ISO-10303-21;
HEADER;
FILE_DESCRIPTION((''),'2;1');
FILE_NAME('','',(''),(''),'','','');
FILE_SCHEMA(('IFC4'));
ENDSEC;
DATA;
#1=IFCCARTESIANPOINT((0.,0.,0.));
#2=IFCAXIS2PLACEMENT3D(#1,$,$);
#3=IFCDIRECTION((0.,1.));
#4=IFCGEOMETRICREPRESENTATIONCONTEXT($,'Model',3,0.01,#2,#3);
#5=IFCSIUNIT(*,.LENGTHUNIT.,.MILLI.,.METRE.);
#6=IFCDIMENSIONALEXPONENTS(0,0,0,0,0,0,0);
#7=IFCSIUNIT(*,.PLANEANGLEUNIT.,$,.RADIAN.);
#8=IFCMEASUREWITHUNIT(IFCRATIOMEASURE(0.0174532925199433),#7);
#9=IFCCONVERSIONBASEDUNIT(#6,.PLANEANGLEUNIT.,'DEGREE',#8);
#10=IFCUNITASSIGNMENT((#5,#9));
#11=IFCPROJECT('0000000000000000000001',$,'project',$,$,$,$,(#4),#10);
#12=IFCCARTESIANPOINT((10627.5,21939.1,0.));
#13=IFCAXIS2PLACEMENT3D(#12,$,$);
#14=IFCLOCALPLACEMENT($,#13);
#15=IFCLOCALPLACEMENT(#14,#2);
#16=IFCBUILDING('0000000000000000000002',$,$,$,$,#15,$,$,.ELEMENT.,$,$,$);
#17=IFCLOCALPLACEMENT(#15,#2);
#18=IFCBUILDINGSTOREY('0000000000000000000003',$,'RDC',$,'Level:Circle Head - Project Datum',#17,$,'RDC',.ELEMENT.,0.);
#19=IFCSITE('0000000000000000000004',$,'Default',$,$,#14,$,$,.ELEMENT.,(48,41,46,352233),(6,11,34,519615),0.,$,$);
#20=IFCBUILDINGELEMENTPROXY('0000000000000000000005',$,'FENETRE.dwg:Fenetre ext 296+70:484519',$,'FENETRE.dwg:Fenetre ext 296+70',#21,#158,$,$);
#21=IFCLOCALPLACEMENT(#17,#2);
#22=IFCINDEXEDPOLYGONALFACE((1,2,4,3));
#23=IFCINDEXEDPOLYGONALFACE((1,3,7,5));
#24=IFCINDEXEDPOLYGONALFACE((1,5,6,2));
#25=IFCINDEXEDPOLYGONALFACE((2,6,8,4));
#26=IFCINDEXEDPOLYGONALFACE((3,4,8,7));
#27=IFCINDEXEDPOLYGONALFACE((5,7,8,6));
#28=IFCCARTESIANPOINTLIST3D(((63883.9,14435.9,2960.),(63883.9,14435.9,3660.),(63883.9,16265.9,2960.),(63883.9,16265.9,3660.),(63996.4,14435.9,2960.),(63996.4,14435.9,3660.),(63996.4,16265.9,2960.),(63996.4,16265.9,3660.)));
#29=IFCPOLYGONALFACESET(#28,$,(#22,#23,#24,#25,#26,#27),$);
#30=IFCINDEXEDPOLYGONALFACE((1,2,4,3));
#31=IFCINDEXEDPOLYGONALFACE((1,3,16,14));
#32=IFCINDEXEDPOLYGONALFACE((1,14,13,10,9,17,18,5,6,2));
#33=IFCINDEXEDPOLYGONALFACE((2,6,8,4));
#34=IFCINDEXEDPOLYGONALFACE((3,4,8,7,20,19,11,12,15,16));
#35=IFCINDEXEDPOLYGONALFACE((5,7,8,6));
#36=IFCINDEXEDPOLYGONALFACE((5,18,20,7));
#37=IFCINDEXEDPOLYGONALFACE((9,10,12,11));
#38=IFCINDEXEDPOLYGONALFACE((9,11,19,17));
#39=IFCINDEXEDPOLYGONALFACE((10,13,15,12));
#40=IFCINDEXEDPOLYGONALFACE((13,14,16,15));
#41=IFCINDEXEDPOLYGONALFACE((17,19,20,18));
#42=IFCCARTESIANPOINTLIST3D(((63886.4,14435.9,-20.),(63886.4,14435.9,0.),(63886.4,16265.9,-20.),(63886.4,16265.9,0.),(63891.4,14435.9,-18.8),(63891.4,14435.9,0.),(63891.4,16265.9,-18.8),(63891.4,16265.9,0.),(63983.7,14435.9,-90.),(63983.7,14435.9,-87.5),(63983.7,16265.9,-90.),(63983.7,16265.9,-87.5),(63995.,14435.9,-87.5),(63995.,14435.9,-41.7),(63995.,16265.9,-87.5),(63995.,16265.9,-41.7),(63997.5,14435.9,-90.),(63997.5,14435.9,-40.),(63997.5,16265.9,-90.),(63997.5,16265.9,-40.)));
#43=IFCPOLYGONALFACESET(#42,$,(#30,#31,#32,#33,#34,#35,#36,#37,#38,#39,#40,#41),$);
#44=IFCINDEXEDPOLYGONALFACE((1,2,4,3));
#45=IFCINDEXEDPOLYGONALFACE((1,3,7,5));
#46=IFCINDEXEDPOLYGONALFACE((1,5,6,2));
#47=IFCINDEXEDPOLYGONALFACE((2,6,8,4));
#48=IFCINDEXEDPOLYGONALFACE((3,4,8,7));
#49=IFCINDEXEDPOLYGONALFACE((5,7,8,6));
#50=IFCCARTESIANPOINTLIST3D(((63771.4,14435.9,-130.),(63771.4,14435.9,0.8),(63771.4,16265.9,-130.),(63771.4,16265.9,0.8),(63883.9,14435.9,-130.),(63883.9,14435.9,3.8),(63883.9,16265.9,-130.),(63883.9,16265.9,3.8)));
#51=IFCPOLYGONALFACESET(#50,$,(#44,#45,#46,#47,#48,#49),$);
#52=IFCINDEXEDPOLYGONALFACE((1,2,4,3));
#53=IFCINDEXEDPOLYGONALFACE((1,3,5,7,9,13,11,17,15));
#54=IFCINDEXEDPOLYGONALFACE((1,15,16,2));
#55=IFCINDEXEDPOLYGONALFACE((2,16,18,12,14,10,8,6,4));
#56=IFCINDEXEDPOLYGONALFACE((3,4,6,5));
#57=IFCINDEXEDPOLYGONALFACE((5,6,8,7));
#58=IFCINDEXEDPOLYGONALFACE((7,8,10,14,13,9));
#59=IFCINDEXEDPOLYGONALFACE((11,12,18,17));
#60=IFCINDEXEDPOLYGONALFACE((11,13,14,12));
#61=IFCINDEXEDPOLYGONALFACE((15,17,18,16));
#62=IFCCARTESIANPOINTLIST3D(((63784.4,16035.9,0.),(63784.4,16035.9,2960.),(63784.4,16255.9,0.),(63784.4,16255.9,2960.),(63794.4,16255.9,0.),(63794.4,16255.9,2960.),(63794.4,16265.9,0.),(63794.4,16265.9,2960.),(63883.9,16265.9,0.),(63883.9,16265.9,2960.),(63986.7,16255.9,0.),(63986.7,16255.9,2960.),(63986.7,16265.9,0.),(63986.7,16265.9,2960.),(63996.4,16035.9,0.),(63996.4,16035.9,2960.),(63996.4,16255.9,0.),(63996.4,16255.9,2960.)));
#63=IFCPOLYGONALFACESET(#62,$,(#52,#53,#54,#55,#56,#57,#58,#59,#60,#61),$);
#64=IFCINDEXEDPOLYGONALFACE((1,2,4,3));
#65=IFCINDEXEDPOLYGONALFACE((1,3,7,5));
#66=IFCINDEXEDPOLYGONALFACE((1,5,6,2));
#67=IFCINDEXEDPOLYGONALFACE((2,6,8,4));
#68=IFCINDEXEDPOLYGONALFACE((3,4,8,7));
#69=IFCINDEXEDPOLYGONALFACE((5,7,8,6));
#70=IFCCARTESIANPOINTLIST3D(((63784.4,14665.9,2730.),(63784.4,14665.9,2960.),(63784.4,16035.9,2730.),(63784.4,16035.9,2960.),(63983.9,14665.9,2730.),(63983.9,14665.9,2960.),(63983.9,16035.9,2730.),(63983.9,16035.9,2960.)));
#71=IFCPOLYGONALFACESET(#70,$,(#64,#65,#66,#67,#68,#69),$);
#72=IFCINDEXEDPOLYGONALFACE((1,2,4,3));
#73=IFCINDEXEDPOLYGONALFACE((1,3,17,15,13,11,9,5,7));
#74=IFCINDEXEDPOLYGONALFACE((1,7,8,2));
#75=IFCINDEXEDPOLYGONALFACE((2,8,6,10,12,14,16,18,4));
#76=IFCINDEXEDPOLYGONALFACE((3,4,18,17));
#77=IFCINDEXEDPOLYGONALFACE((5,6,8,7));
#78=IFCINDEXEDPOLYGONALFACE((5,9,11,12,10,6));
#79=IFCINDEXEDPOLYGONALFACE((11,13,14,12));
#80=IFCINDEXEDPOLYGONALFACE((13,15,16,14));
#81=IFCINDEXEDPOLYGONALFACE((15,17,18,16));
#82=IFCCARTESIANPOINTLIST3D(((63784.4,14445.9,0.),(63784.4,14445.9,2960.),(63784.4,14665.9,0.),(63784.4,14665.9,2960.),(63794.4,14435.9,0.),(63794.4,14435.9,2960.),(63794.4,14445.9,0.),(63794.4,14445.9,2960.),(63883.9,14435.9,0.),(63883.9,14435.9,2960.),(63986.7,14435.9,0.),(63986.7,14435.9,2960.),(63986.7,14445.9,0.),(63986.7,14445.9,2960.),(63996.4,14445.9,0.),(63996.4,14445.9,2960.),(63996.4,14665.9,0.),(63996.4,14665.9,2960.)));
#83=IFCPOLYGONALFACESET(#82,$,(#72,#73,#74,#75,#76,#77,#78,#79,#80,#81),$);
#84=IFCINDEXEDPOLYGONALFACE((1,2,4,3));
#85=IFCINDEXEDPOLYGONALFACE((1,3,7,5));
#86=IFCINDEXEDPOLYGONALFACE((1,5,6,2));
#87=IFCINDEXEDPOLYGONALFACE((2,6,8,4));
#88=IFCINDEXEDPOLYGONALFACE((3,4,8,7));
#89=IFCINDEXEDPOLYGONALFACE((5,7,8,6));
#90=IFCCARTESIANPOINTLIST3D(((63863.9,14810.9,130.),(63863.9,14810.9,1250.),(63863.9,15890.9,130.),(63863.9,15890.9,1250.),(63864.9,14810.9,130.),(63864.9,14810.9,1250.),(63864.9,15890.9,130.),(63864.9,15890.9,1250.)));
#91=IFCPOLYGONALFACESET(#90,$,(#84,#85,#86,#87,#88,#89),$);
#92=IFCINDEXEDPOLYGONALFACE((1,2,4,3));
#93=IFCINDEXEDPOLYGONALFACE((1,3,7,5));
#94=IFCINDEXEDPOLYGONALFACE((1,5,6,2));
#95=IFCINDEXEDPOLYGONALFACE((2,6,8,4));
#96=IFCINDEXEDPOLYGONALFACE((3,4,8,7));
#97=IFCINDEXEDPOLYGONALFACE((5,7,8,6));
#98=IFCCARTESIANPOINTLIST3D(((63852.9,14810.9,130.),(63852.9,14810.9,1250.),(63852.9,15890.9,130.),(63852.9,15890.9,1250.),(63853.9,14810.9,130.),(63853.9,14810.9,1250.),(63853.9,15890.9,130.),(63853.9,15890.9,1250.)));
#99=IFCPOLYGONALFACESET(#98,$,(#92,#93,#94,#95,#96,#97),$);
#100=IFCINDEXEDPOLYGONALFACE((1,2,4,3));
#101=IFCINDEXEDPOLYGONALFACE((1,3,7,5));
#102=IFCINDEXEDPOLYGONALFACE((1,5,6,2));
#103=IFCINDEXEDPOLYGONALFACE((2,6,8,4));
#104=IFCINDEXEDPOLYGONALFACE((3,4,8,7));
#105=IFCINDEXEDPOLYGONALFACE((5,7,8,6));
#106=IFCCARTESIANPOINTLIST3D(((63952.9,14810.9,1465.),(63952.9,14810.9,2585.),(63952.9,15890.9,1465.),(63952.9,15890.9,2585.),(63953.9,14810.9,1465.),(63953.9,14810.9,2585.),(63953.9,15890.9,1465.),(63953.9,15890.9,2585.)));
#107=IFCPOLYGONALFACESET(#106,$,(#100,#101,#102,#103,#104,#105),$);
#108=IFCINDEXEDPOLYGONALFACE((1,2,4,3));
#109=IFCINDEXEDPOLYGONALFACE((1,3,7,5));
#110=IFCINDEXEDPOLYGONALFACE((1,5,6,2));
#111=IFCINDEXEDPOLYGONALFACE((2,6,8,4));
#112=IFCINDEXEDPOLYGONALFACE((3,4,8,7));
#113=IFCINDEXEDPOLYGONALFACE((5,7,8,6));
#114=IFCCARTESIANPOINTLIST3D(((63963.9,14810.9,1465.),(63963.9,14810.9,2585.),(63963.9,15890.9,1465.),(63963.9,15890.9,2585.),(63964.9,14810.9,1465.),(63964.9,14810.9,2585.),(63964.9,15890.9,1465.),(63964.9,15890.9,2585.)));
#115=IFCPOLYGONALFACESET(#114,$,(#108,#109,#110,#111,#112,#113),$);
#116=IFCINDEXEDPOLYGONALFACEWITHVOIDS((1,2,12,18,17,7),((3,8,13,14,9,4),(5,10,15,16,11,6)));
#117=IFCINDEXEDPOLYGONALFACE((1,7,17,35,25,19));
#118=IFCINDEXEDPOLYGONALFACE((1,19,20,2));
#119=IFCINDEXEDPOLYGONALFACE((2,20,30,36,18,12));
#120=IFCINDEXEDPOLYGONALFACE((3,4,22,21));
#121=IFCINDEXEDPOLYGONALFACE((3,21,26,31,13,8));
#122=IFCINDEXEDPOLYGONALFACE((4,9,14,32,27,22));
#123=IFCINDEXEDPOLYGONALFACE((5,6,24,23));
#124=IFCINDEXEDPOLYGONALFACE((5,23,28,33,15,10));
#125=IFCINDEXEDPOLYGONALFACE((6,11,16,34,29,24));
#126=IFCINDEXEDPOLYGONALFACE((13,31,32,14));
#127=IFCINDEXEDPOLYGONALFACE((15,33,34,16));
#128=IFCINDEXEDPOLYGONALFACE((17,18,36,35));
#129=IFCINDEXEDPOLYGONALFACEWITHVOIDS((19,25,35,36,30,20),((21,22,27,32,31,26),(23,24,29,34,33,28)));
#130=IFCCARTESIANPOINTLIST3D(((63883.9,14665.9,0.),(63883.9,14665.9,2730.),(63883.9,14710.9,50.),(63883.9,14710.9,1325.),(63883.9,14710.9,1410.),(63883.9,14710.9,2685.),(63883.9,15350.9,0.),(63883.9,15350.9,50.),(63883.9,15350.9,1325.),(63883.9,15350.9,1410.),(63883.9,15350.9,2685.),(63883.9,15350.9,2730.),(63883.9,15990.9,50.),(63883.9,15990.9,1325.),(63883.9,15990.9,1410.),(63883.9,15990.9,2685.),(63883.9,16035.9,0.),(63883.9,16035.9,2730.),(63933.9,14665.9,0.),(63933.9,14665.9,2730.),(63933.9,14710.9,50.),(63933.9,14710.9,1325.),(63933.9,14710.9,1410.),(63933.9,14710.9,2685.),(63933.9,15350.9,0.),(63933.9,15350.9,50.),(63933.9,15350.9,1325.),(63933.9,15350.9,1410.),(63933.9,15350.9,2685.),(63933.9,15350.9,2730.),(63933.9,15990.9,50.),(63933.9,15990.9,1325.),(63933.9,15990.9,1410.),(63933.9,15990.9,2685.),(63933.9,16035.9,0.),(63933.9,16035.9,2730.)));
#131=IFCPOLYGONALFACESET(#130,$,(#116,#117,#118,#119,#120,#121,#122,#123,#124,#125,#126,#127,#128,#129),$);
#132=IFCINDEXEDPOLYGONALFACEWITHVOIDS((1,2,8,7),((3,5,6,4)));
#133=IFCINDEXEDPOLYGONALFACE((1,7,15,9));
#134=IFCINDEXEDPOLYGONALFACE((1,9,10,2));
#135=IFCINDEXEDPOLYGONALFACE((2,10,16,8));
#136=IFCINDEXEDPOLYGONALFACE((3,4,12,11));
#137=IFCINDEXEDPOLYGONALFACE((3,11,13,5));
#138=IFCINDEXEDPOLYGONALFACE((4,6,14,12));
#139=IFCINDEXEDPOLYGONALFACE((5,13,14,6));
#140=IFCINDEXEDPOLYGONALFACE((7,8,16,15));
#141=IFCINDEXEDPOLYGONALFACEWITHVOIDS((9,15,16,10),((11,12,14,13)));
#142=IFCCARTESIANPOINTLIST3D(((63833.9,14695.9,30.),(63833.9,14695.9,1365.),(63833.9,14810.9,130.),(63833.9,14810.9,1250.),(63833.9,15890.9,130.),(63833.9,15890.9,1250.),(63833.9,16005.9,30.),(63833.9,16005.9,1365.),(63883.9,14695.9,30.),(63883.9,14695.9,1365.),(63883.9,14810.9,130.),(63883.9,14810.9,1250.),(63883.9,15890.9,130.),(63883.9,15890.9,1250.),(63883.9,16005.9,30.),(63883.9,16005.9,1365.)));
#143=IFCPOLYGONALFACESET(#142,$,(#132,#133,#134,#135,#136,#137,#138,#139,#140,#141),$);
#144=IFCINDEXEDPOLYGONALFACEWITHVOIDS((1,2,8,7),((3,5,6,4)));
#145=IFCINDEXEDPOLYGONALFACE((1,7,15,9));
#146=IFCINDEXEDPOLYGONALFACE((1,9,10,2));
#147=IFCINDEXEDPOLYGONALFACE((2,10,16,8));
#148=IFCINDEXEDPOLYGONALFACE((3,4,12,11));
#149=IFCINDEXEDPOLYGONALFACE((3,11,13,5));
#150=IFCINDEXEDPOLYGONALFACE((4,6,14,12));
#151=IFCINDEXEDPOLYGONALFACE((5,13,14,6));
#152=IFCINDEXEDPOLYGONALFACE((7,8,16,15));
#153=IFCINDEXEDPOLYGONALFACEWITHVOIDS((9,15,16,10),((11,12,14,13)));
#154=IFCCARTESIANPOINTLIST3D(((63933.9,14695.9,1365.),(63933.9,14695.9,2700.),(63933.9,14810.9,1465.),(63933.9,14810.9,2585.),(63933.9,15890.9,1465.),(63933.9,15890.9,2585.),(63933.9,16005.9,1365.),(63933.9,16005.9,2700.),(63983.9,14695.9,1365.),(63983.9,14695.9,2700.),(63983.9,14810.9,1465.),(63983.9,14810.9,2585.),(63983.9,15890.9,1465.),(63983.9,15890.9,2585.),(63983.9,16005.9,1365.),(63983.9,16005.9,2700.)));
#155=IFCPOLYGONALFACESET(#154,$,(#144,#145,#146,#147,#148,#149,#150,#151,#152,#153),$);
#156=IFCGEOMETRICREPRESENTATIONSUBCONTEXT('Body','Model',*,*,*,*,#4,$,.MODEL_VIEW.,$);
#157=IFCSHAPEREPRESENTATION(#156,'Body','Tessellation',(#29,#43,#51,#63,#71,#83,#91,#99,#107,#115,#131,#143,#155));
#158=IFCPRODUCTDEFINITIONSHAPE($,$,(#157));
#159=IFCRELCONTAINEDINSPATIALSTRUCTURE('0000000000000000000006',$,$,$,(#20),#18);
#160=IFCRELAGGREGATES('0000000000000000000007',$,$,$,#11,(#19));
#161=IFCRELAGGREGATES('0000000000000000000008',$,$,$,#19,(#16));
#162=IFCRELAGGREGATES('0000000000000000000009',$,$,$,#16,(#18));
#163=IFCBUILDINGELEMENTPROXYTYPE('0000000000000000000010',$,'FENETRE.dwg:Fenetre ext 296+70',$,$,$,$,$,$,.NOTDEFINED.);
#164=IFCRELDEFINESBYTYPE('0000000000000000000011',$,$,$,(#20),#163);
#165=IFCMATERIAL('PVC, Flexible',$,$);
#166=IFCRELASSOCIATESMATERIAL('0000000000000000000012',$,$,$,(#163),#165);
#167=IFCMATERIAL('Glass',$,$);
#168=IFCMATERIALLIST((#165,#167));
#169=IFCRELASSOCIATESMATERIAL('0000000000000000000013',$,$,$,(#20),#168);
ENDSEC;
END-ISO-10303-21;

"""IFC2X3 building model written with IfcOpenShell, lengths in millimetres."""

from ifc_helpers import new_model, entity, si_unit, converted_unit, direction, frame, frame_2d, origin, origin_2d_with_axis, place, context, subcontext, project, spatial, polyline, rectangle, outline, extrude, source, transform, mapped, material, material_list, type_object, type_shapes, element, save


model = new_model("IFC2X3")

# Units and contexts
model_context = context("Model", 3, precision=0.01, world=origin(), true_north=direction((0.0, 1.0)))
body_context = subcontext(model_context, "Body", "Model", "MODEL_VIEW")
ifc_project = project(units=[si_unit("LENGTHUNIT", "METRE", prefix="MILLI"), converted_unit("PLANEANGLEUNIT", "DEGREE", entity("IfcRatioMeasure", 0.0174532925199433), si_unit("PLANEANGLEUNIT", "RADIAN"), dimensions=[0, 0, 0, 0, 0, 0, 0])], contexts=[model_context])

# Site, building, storey
site_placement = place(None, frame((10627.5, 21939.1, 0.0)))
site = spatial("IfcSite", under=ifc_project, at=site_placement, Name="Default", CompositionType="ELEMENT", RefLatitude=(48, 41, 46, 352233), RefLongitude=(6, 11, 34, 519615), RefElevation=0.0)
building_placement = place(site_placement, origin())
building = spatial("IfcBuilding", under=site, at=building_placement, CompositionType="ELEMENT")
storey_placement = place(building_placement, origin())
storey = spatial("IfcBuildingStorey", under=building, at=storey_placement, Name="RDC", ObjectType="Level:Circle Head - Project Datum", LongName="RDC", CompositionType="ELEMENT", Elevation=0.0)

# Building element proxy
ifc_material_1 = material(Name="PVC, Flexible")
ifc_material_2 = material(Name="Glass")
ifc_material_list_1 = material_list([ifc_material_1, ifc_material_2])
building_element_proxy_type_1 = type_object("IfcBuildingElementProxyType", Name="FENETRE.dwg:Fenetre ext 296+70", PredefinedType="NOTDEFINED", material=ifc_material_1)
shared_shape_1 = source(origin(), body_context, "Body", "SweptSolid", [
    extrude(rectangle(XDim=112.5, YDim=1830.0, at=origin_2d_with_axis()), frame((-10.4, -56.3, 2960.0), z_axis=(0.0, 0.0, 1.0), x_axis=(0.0, 1.0, 0.0)), (0.0, 0.0, 1.0), 700.0),
    extrude(outline(polyline([(27.5, -64.4), (47.5, -64.4), (47.5, -59.4), (28.8, -59.4), (7.5, 46.7), (-42.5, 46.7), (-42.5, 32.9), (-40.0, 32.9), (-40.0, 44.2), (5.8, 44.2), (27.5, -64.4)])), frame((-925.4, -66.9, -47.5), z_axis=(1.0, 0.0, 0.0), x_axis=(0.0, 0.0, 1.0)), (0.0, 0.0, 1.0), 1830.0),
    extrude(outline(polyline([(-54.5, -66.1), (58.0, -66.1), (54.5, 67.6), (-58.0, 64.6), (-54.5, -66.1)])), frame((-925.4, 56.3, -63.8), z_axis=(1.0, 0.0, 0.0), x_axis=(0.0, -0.999645, 0.02665)), (0.0, 0.0, 1.0), 1830.0),
    extrude(outline(polyline([(-97.0, -55.6), (5.9, -55.6), (95.4, -55.6), (95.4, -45.6), (105.4, -45.6), (105.4, 174.4), (-106.6, 174.4), (-106.6, -45.6), (-97.0, -45.6), (-97.0, -55.6)])), frame((849.0, -5.9, 0.0), z_axis=(0.0, 0.0, 1.0), x_axis=(0.0, 1.0, 0.0)), (0.0, 0.0, 1.0), 2960.0),
    extrude(rectangle(XDim=1370.0, YDim=199.5, at=origin_2d_with_axis()), frame((-10.4, -0.3, 2730.0), z_axis=(0.0, 0.0, 1.0), x_axis=(-1.0, 0.0, 0.0)), (0.0, 0.0, 1.0), 230.0),
    extrude(outline(polyline([(-55.6, 97.0), (-55.6, -5.9), (-55.6, -95.4), (-45.6, -95.4), (-45.6, -105.4), (174.4, -105.4), (174.4, 106.6), (-45.6, 106.6), (-45.6, 97.0), (-55.6, 97.0)])), frame((-869.9, -5.9, 0.0), z_axis=(0.0, 0.0, -1.0), x_axis=(1.0, 0.0, 0.0)), (0.0, 0.0, -1.0), 2960.0),
    extrude(rectangle(XDim=1080.0, YDim=1.0, at=origin_2d_with_axis()), frame((-10.4, 19.5, 130.0), z_axis=(0.0, 0.0, 1.0), x_axis=(-1.0, 0.0, 0.0)), (0.0, 0.0, 1.0), 1120.0),
    extrude(rectangle(XDim=1080.0, YDim=1.0, at=origin_2d_with_axis()), frame((-10.4, 30.5, 130.0), z_axis=(0.0, 0.0, 1.0), x_axis=(-1.0, 0.0, 0.0)), (0.0, 0.0, 1.0), 1120.0),
    extrude(rectangle(XDim=1080.0, YDim=1.0, at=frame_2d((0.0, 0.0), x_axis=(1.0, 0.0))), frame((-10.4, -69.5, 1465.0), z_axis=(0.0, 0.0, 1.0), x_axis=(-1.0, 0.0, 0.0)), (0.0, 0.0, 1.0), 1120.0),
    extrude(rectangle(XDim=1080.0, YDim=1.0, at=frame_2d((0.0, 0.0), x_axis=(1.0, 0.0))), frame((-10.4, -80.5, 1465.0), z_axis=(0.0, 0.0, 1.0), x_axis=(-1.0, 0.0, 0.0)), (0.0, 0.0, 1.0), 1120.0),
    extrude(outline(polyline([(-685.0, -1365.0), (0.0, -1365.0), (685.0, -1365.0), (685.0, 1365.0), (0.0, 1365.0), (-685.0, 1365.0), (-685.0, -1365.0)]), holes=[polyline([(-640.0, -1320.0), (-640.0, -45.0), (0.0, -45.0), (640.0, -45.0), (640.0, -1320.0), (0.0, -1320.0), (-640.0, -1320.0)]), polyline([(-640.0, 40.0), (-640.0, 1315.0), (0.0, 1315.0), (640.0, 1315.0), (640.0, 40.0), (0.0, 40.0), (-640.0, 40.0)])]), frame((-10.4, -50.0, 1365.0), z_axis=(0.0, 1.0, 0.0), x_axis=(1.0, 0.0, 0.0)), (0.0, 0.0, 1.0), 50.0),
    extrude(outline(polyline([(-655.0, -667.5), (655.0, -667.5), (655.0, 667.5), (-655.0, 667.5), (-655.0, -667.5)]), holes=[polyline([(-540.0, 552.5), (540.0, 552.5), (540.0, -567.5), (-540.0, -567.5), (-540.0, 552.5)])]), frame((-10.4, 0.0, 697.5), z_axis=(0.0, 1.0, 0.0), x_axis=(-1.0, 0.0, 0.0)), (0.0, 0.0, 1.0), 50.0),
    extrude(outline(polyline([(-655.0, -667.5), (655.0, -667.5), (655.0, 667.5), (-655.0, 667.5), (-655.0, -667.5)]), holes=[polyline([(-540.0, 552.5), (540.0, 552.5), (540.0, -567.5), (-540.0, -567.5), (-540.0, 552.5)])]), frame((-10.4, -100.0, 2032.5), z_axis=(0.0, 1.0, 0.0), x_axis=(-1.0, 0.0, 0.0)), (0.0, 0.0, 1.0), 50.0),
])
type_shapes(building_element_proxy_type_1, [shared_shape_1])
proxy_1_placement = place(storey_placement, frame((63883.9, 15361.3, 0.0), z_axis=(0.0, 0.0, 1.0), x_axis=(0.0, 1.0, 0.0)))
element("IfcBuildingElementProxy", 1, at=proxy_1_placement, inside=storey, type_object=building_element_proxy_type_1, material=ifc_material_list_1, Name="FENETRE.dwg:Fenetre ext 296+70:484519", ObjectType="FENETRE.dwg:Fenetre ext 296+70", context=body_context, shape_type="MappedRepresentation", body=[
    mapped(shared_shape_1, transform((0.0, 0.0, 0.0), scale=1.0)),
])

save(model, "model.ifc")
